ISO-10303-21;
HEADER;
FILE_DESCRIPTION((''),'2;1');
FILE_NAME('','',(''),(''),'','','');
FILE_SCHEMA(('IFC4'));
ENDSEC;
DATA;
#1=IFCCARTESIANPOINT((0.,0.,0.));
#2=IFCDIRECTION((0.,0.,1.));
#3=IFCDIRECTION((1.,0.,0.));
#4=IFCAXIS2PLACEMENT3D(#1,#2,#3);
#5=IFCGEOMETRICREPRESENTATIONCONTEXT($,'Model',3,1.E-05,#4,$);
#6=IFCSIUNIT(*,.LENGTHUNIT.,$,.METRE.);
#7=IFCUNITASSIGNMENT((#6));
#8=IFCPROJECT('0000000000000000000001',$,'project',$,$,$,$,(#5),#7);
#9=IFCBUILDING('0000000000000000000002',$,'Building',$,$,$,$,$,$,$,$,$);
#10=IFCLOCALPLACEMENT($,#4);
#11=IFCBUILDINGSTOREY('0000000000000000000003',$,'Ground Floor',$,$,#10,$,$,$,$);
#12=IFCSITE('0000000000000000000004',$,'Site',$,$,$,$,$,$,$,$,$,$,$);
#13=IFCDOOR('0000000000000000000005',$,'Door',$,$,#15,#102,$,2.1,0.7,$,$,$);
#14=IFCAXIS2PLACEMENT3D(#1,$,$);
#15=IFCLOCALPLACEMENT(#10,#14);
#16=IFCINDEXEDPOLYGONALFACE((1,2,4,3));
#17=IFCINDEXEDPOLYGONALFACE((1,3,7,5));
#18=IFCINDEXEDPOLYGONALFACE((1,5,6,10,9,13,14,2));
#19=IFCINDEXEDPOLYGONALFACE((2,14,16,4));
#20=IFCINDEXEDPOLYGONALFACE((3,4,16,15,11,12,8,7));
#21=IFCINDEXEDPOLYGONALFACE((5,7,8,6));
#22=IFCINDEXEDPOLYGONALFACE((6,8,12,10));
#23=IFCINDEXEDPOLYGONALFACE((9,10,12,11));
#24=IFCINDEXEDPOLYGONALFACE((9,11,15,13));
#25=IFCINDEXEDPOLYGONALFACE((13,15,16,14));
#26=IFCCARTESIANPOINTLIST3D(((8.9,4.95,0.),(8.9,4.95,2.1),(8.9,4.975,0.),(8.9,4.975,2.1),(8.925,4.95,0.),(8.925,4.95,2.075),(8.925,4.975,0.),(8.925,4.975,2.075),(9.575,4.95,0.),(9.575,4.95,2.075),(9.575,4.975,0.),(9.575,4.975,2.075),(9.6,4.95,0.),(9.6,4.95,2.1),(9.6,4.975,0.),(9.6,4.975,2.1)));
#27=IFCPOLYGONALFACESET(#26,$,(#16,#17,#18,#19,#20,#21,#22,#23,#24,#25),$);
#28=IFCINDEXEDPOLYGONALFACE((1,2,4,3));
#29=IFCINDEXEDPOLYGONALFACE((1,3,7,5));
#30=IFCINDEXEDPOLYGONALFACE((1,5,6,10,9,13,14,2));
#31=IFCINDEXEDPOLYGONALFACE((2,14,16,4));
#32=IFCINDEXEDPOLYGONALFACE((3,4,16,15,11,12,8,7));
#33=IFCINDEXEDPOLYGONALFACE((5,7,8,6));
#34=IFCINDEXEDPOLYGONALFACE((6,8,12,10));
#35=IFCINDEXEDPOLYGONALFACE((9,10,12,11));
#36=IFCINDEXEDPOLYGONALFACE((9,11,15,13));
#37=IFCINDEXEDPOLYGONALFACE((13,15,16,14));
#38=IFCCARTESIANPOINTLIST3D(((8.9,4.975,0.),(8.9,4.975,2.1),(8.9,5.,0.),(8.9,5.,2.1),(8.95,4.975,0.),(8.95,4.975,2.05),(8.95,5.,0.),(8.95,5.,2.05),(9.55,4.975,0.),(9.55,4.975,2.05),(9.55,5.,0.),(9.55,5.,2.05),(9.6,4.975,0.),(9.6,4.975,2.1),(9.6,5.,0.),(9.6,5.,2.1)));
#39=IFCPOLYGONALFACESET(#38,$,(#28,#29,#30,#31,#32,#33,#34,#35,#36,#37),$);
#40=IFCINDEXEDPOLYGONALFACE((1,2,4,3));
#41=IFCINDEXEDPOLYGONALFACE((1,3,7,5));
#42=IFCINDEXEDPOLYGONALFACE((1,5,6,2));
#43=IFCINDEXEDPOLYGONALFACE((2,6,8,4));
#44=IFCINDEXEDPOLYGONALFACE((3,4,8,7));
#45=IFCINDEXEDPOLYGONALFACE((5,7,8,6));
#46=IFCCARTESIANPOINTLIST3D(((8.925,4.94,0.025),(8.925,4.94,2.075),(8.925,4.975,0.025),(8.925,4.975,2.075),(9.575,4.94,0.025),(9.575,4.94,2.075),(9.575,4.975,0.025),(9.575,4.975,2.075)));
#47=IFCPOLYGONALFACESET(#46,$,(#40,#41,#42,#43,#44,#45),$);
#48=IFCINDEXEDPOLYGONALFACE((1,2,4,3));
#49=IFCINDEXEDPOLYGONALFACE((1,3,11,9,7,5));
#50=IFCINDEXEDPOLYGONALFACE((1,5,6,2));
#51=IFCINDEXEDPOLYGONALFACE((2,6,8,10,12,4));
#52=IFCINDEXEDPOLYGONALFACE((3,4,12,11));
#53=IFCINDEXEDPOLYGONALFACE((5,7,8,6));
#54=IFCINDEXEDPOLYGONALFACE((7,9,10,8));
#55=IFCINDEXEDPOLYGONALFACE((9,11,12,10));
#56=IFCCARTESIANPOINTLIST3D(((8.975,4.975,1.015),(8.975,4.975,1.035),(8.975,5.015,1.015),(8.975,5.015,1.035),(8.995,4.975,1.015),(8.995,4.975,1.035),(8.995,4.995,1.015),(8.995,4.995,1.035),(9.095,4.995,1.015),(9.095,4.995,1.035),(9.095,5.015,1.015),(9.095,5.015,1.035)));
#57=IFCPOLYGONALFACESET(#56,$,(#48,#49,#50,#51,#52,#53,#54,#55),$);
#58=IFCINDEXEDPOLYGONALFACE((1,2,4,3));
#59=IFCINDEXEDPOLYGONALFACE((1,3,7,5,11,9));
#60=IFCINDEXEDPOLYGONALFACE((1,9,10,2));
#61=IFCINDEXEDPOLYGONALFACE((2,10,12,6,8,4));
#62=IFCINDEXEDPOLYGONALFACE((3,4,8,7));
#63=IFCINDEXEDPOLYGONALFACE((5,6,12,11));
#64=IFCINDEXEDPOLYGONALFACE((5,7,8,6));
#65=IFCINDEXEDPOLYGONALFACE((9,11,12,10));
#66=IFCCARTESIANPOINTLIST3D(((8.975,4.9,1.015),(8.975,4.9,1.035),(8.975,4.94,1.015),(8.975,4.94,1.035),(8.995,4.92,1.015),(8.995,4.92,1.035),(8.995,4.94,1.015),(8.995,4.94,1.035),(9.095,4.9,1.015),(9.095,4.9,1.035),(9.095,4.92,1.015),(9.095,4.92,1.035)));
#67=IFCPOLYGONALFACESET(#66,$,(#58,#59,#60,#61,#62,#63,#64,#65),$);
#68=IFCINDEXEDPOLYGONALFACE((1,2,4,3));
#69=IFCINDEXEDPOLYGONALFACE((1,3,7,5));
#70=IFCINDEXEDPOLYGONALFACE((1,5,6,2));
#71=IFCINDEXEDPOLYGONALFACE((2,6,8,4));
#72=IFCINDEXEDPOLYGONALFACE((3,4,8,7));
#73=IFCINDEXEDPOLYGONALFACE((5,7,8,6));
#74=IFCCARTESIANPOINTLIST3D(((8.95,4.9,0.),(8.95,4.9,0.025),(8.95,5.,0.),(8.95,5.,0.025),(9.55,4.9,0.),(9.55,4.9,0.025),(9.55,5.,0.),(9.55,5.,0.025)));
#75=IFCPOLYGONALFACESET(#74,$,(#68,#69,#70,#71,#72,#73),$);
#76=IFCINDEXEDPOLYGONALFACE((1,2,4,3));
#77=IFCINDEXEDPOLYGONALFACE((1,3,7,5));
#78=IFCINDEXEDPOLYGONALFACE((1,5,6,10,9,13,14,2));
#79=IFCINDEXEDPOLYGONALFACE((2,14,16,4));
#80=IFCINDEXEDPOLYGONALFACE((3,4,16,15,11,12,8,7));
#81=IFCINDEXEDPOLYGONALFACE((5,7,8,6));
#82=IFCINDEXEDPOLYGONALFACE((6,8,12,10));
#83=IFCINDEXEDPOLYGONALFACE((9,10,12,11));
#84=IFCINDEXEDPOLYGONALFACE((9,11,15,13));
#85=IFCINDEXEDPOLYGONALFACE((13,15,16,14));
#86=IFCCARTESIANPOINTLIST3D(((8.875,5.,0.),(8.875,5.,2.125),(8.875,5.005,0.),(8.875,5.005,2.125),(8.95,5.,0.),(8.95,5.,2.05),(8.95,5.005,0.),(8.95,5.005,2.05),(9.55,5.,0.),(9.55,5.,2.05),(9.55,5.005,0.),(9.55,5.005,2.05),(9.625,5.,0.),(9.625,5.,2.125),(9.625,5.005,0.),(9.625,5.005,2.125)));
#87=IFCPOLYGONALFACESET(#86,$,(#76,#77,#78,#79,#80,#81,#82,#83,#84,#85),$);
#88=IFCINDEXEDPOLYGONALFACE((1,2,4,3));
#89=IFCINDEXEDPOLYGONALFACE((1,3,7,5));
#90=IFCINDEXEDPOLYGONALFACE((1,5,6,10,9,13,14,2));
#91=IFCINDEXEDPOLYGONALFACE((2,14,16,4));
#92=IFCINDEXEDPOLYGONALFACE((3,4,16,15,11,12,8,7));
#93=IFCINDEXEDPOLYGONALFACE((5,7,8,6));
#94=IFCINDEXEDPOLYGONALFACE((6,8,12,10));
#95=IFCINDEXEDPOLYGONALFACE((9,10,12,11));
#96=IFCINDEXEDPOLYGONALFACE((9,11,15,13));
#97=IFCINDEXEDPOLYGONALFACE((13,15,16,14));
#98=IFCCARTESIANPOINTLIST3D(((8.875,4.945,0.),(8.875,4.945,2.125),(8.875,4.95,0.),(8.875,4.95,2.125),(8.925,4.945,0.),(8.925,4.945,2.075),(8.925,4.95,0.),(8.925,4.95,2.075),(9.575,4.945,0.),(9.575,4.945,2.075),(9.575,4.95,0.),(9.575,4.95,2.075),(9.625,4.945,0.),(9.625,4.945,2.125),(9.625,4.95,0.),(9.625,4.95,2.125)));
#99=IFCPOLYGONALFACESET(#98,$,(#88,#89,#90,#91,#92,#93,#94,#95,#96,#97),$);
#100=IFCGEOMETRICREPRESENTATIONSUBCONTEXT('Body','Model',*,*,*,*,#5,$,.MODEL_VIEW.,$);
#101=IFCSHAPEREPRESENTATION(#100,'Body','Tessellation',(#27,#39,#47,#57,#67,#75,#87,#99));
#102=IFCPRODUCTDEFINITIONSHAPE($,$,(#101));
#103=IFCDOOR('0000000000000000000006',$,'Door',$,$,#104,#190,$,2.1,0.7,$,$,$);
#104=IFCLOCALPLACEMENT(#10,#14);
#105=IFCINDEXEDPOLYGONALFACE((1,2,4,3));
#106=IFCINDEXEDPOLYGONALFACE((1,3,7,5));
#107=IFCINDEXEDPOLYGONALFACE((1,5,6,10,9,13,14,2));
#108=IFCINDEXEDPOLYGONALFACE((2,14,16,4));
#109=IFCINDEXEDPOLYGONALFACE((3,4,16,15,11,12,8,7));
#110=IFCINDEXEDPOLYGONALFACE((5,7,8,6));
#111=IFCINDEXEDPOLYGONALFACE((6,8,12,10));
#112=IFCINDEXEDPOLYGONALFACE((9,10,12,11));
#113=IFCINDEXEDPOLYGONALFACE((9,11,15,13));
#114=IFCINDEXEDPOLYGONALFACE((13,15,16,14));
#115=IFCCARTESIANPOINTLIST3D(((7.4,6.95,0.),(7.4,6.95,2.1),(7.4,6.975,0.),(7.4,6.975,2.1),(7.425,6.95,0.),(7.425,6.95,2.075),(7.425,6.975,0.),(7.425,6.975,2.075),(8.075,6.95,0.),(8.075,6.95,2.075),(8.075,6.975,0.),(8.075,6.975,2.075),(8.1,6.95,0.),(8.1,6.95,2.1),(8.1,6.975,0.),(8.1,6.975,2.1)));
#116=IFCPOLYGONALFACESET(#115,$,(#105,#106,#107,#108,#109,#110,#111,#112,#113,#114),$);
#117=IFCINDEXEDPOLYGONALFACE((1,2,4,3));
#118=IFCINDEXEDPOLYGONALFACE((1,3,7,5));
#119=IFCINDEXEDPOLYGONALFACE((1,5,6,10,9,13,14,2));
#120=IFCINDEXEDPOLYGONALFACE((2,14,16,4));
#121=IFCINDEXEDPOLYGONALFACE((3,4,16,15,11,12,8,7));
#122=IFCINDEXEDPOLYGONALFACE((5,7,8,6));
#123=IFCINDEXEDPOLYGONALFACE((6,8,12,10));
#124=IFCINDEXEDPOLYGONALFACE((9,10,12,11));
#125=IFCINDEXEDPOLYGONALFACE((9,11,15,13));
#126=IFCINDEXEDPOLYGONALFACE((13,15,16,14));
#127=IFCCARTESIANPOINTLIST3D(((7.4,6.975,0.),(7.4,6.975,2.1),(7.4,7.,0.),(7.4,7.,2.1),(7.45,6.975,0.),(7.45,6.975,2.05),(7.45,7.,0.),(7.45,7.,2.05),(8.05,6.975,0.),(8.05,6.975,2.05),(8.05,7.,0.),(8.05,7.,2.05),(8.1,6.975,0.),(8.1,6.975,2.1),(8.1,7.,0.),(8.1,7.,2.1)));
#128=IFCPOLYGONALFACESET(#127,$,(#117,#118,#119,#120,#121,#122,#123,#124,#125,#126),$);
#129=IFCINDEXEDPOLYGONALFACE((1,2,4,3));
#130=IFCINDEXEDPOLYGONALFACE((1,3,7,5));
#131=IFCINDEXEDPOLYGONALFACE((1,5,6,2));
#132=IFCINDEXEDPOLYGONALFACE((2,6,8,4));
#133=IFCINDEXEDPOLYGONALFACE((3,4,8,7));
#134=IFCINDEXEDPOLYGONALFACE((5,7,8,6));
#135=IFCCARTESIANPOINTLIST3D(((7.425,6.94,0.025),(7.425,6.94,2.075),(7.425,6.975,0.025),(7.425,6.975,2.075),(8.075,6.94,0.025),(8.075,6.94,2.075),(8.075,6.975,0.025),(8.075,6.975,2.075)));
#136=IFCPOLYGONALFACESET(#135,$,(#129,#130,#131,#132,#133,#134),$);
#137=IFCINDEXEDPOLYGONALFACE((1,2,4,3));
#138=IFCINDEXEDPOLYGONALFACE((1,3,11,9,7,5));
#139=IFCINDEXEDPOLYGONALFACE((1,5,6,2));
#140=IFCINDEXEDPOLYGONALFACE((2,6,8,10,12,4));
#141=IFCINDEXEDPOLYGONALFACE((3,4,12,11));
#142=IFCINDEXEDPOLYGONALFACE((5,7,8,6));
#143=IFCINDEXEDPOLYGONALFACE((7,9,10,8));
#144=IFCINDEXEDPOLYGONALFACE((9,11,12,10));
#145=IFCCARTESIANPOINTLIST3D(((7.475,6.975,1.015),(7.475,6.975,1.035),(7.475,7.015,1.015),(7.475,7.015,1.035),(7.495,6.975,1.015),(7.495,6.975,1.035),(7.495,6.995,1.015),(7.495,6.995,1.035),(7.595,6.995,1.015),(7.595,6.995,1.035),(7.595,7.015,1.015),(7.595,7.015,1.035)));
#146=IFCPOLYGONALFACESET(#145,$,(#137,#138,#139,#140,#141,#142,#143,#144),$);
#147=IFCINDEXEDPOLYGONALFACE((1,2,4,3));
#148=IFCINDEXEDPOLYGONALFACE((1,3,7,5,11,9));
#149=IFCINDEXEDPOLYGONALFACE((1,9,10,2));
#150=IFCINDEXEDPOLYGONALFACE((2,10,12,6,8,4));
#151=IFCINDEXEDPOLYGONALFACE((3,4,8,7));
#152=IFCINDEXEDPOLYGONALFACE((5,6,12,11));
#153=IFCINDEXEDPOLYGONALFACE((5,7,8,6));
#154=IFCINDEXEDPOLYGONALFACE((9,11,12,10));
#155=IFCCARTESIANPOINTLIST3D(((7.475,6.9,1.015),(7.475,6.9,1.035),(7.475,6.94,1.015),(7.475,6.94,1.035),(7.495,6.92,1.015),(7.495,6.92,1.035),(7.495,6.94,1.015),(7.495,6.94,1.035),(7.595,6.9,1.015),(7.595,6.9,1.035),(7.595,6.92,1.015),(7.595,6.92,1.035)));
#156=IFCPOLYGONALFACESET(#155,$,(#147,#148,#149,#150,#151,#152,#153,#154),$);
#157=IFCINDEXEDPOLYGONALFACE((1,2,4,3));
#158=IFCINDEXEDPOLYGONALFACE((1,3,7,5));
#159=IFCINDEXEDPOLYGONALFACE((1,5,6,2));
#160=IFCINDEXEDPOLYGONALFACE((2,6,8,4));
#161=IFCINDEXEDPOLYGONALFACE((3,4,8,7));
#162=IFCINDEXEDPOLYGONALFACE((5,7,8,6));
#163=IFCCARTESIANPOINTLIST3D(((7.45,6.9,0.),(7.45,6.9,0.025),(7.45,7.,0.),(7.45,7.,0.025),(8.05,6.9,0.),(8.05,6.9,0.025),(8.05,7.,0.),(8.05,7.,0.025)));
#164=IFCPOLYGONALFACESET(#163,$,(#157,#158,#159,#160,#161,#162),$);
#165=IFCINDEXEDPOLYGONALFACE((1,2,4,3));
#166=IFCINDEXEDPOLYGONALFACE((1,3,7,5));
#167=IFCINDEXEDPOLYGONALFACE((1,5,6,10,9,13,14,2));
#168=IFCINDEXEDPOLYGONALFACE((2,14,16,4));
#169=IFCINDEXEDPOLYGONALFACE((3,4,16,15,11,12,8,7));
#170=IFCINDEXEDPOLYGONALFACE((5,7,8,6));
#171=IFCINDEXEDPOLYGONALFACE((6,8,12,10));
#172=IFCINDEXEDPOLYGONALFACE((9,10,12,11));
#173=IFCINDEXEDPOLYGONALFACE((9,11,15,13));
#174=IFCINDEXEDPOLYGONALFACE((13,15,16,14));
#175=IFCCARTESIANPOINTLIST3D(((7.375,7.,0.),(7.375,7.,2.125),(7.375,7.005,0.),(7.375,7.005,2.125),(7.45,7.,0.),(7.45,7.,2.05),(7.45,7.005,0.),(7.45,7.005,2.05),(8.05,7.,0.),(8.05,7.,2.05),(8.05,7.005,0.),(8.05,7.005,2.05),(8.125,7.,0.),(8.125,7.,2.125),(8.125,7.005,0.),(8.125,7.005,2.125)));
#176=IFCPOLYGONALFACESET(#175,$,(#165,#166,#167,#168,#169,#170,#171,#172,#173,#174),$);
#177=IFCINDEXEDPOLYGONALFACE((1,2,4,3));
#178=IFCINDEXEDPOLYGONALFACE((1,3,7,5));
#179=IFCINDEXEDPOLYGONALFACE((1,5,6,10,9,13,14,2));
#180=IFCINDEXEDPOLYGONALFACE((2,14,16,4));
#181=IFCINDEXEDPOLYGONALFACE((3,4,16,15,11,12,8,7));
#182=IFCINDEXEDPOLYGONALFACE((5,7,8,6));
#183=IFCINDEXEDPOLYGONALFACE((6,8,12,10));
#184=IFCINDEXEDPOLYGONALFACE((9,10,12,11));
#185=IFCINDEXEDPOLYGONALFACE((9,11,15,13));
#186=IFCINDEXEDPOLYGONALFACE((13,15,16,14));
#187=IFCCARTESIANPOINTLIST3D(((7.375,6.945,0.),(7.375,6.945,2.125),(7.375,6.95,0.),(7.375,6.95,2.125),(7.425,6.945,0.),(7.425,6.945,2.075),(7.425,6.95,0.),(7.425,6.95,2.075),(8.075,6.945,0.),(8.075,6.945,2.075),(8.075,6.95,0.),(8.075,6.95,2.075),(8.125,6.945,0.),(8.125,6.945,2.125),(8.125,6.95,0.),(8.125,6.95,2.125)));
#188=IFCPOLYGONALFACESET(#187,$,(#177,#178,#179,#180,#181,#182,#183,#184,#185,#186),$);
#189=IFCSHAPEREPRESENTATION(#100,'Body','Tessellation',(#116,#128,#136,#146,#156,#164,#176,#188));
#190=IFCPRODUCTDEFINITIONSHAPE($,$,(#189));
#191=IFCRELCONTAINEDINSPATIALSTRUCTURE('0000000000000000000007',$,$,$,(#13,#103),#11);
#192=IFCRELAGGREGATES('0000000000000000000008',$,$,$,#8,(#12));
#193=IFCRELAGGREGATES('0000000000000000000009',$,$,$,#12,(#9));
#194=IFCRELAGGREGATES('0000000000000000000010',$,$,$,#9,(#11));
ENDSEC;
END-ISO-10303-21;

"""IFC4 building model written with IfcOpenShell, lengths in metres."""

from ifc_helpers import new_model, si_unit, frame, origin_with_axes, place, context, subcontext, project, spatial, line, indexed_curve, outline, extrude, element, save


model = new_model("IFC4")

# Units and contexts
model_context = context("Model", 3, precision=1e-05, world=origin_with_axes())
body_context = subcontext(model_context, "Body", "Model", "MODEL_VIEW")
ifc_project = project(units=[si_unit("LENGTHUNIT", "METRE")], contexts=[model_context])

# Site, building, storey
site = spatial("IfcSite", under=ifc_project, Name="Site")
building = spatial("IfcBuilding", under=site, Name="Building")
storey_placement = place(None, origin_with_axes())
storey = spatial("IfcBuildingStorey", under=building, at=storey_placement, Name="Ground Floor")

# Doors
door_1_placement = place(storey_placement, frame((9.6, 5.0, 0.0), z_axis=(0.0, 0.0, 1.0), x_axis=(-1.0, 0.0, 0.0)))
element("IfcDoor", 1, at=door_1_placement, inside=storey, Name="Door", OverallHeight=2.1, OverallWidth=0.7, context=body_context, shape_type="SweptSolid", body=[
    extrude(outline(indexed_curve([(0.0, 0.0), (0.0, 2.1), (0.7, 2.1), (0.7, 0.0), (0.675, 0.0), (0.675, 2.075), (0.025, 2.075), (0.025, 0.0)], segments=[line(1, 2, 3, 4, 5, 6, 7, 8, 1)])), frame((0.0, 0.025, 0.0), z_axis=(0.0, -1.0, 0.0), x_axis=(1.0, 0.0, 0.0)), (0.0, 0.0, -1.0), 0.025),
    extrude(outline(indexed_curve([(0.0, 0.0), (0.0, 2.1), (0.7, 2.1), (0.7, 0.0), (0.65, 0.0), (0.65, 2.05), (0.05, 2.05), (0.05, 0.0)], segments=[line(1, 2, 3, 4, 5, 6, 7, 8, 1)])), frame((0.0, 0.0, 0.0), z_axis=(0.0, -1.0, 0.0), x_axis=(1.0, 0.0, 0.0)), (0.0, 0.0, -1.0), 0.025),
    extrude(outline(indexed_curve([(0.0, 0.0), (0.65, 0.0), (0.65, 0.035), (0.0, 0.035)], segments=[line(1, 2, 3, 4, 1)])), frame((0.025, 0.025, 0.025), z_axis=(0.0, 0.0, 1.0), x_axis=(1.0, 0.0, 0.0)), (0.0, 0.0, 1.0), 2.05),
    extrude(outline(indexed_curve([(0.0, 0.0), (0.0, -0.04), (-0.12, -0.04), (-0.12, -0.02), (-0.02, -0.02), (-0.02, 0.0)], segments=[line(1, 2, 3, 4, 5, 6, 1)])), frame((0.625, 0.025, 1.015), z_axis=(0.0, 0.0, 1.0), x_axis=(1.0, 0.0, 0.0)), (0.0, 0.0, 1.0), 0.02),
    extrude(outline(indexed_curve([(0.0, 0.0), (0.0, 0.04), (-0.12, 0.04), (-0.12, 0.02), (-0.02, 0.02), (-0.02, 0.0)], segments=[line(1, 2, 3, 4, 5, 6, 1)])), frame((0.625, 0.06, 1.015), z_axis=(0.0, 0.0, 1.0), x_axis=(1.0, 0.0, 0.0)), (0.0, 0.0, 1.0), 0.02),
    extrude(outline(indexed_curve([(0.0, 0.0), (0.6, 0.0), (0.6, 0.1), (0.0, 0.1)], segments=[line(1, 2, 3, 4, 1)])), frame((0.05, 0.0, 0.0), z_axis=(0.0, 0.0, 1.0), x_axis=(1.0, 0.0, 0.0)), (0.0, 0.0, 1.0), 0.025),
    extrude(outline(indexed_curve([(0.0, 0.0), (0.0, 2.125), (0.75, 2.125), (0.75, 0.0), (0.675, 0.0), (0.675, 2.05), (0.075, 2.05), (0.075, 0.0)], segments=[line(1, 2, 3, 4, 5, 6, 7, 8, 1)])), frame((-0.025, -0.005, 0.0), z_axis=(0.0, -1.0, 0.0), x_axis=(1.0, 0.0, 0.0)), (0.0, 0.0, -1.0), 0.005),
    extrude(outline(indexed_curve([(0.0, 0.0), (0.0, 2.125), (0.75, 2.125), (0.75, 0.0), (0.7, 0.0), (0.7, 2.075), (0.05, 2.075), (0.05, 0.0)], segments=[line(1, 2, 3, 4, 5, 6, 7, 8, 1)])), frame((-0.025, 0.05, 0.0), z_axis=(0.0, -1.0, 0.0), x_axis=(1.0, 0.0, 0.0)), (0.0, 0.0, -1.0), 0.005),
])
door_2_placement = place(storey_placement, frame((8.1, 7.0, 0.0), z_axis=(0.0, 0.0, 1.0), x_axis=(-1.0, 0.0, 0.0)))
element("IfcDoor", 2, at=door_2_placement, inside=storey, Name="Door", OverallHeight=2.1, OverallWidth=0.7, context=body_context, shape_type="SweptSolid", body=[
    extrude(outline(indexed_curve([(0.0, 0.0), (0.0, 2.1), (0.7, 2.1), (0.7, 0.0), (0.675, 0.0), (0.675, 2.075), (0.025, 2.075), (0.025, 0.0)], segments=[line(1, 2, 3, 4, 5, 6, 7, 8, 1)])), frame((0.0, 0.025, 0.0), z_axis=(0.0, -1.0, 0.0), x_axis=(1.0, 0.0, 0.0)), (0.0, 0.0, -1.0), 0.025),
    extrude(outline(indexed_curve([(0.0, 0.0), (0.0, 2.1), (0.7, 2.1), (0.7, 0.0), (0.65, 0.0), (0.65, 2.05), (0.05, 2.05), (0.05, 0.0)], segments=[line(1, 2, 3, 4, 5, 6, 7, 8, 1)])), frame((0.0, 0.0, 0.0), z_axis=(0.0, -1.0, 0.0), x_axis=(1.0, 0.0, 0.0)), (0.0, 0.0, -1.0), 0.025),
    extrude(outline(indexed_curve([(0.0, 0.0), (0.65, 0.0), (0.65, 0.035), (0.0, 0.035)], segments=[line(1, 2, 3, 4, 1)])), frame((0.025, 0.025, 0.025), z_axis=(0.0, 0.0, 1.0), x_axis=(1.0, 0.0, 0.0)), (0.0, 0.0, 1.0), 2.05),
    extrude(outline(indexed_curve([(0.0, 0.0), (0.0, -0.04), (-0.12, -0.04), (-0.12, -0.02), (-0.02, -0.02), (-0.02, 0.0)], segments=[line(1, 2, 3, 4, 5, 6, 1)])), frame((0.625, 0.025, 1.015), z_axis=(0.0, 0.0, 1.0), x_axis=(1.0, 0.0, 0.0)), (0.0, 0.0, 1.0), 0.02),
    extrude(outline(indexed_curve([(0.0, 0.0), (0.0, 0.04), (-0.12, 0.04), (-0.12, 0.02), (-0.02, 0.02), (-0.02, 0.0)], segments=[line(1, 2, 3, 4, 5, 6, 1)])), frame((0.625, 0.06, 1.015), z_axis=(0.0, 0.0, 1.0), x_axis=(1.0, 0.0, 0.0)), (0.0, 0.0, 1.0), 0.02),
    extrude(outline(indexed_curve([(0.0, 0.0), (0.6, 0.0), (0.6, 0.1), (0.0, 0.1)], segments=[line(1, 2, 3, 4, 1)])), frame((0.05, 0.0, 0.0), z_axis=(0.0, 0.0, 1.0), x_axis=(1.0, 0.0, 0.0)), (0.0, 0.0, 1.0), 0.025),
    extrude(outline(indexed_curve([(0.0, 0.0), (0.0, 2.125), (0.75, 2.125), (0.75, 0.0), (0.675, 0.0), (0.675, 2.05), (0.075, 2.05), (0.075, 0.0)], segments=[line(1, 2, 3, 4, 5, 6, 7, 8, 1)])), frame((-0.025, -0.005, 0.0), z_axis=(0.0, -1.0, 0.0), x_axis=(1.0, 0.0, 0.0)), (0.0, 0.0, -1.0), 0.005),
    extrude(outline(indexed_curve([(0.0, 0.0), (0.0, 2.125), (0.75, 2.125), (0.75, 0.0), (0.7, 0.0), (0.7, 2.075), (0.05, 2.075), (0.05, 0.0)], segments=[line(1, 2, 3, 4, 5, 6, 7, 8, 1)])), frame((-0.025, 0.05, 0.0), z_axis=(0.0, -1.0, 0.0), x_axis=(1.0, 0.0, 0.0)), (0.0, 0.0, -1.0), 0.005),
])

save(model, "model.ifc")
